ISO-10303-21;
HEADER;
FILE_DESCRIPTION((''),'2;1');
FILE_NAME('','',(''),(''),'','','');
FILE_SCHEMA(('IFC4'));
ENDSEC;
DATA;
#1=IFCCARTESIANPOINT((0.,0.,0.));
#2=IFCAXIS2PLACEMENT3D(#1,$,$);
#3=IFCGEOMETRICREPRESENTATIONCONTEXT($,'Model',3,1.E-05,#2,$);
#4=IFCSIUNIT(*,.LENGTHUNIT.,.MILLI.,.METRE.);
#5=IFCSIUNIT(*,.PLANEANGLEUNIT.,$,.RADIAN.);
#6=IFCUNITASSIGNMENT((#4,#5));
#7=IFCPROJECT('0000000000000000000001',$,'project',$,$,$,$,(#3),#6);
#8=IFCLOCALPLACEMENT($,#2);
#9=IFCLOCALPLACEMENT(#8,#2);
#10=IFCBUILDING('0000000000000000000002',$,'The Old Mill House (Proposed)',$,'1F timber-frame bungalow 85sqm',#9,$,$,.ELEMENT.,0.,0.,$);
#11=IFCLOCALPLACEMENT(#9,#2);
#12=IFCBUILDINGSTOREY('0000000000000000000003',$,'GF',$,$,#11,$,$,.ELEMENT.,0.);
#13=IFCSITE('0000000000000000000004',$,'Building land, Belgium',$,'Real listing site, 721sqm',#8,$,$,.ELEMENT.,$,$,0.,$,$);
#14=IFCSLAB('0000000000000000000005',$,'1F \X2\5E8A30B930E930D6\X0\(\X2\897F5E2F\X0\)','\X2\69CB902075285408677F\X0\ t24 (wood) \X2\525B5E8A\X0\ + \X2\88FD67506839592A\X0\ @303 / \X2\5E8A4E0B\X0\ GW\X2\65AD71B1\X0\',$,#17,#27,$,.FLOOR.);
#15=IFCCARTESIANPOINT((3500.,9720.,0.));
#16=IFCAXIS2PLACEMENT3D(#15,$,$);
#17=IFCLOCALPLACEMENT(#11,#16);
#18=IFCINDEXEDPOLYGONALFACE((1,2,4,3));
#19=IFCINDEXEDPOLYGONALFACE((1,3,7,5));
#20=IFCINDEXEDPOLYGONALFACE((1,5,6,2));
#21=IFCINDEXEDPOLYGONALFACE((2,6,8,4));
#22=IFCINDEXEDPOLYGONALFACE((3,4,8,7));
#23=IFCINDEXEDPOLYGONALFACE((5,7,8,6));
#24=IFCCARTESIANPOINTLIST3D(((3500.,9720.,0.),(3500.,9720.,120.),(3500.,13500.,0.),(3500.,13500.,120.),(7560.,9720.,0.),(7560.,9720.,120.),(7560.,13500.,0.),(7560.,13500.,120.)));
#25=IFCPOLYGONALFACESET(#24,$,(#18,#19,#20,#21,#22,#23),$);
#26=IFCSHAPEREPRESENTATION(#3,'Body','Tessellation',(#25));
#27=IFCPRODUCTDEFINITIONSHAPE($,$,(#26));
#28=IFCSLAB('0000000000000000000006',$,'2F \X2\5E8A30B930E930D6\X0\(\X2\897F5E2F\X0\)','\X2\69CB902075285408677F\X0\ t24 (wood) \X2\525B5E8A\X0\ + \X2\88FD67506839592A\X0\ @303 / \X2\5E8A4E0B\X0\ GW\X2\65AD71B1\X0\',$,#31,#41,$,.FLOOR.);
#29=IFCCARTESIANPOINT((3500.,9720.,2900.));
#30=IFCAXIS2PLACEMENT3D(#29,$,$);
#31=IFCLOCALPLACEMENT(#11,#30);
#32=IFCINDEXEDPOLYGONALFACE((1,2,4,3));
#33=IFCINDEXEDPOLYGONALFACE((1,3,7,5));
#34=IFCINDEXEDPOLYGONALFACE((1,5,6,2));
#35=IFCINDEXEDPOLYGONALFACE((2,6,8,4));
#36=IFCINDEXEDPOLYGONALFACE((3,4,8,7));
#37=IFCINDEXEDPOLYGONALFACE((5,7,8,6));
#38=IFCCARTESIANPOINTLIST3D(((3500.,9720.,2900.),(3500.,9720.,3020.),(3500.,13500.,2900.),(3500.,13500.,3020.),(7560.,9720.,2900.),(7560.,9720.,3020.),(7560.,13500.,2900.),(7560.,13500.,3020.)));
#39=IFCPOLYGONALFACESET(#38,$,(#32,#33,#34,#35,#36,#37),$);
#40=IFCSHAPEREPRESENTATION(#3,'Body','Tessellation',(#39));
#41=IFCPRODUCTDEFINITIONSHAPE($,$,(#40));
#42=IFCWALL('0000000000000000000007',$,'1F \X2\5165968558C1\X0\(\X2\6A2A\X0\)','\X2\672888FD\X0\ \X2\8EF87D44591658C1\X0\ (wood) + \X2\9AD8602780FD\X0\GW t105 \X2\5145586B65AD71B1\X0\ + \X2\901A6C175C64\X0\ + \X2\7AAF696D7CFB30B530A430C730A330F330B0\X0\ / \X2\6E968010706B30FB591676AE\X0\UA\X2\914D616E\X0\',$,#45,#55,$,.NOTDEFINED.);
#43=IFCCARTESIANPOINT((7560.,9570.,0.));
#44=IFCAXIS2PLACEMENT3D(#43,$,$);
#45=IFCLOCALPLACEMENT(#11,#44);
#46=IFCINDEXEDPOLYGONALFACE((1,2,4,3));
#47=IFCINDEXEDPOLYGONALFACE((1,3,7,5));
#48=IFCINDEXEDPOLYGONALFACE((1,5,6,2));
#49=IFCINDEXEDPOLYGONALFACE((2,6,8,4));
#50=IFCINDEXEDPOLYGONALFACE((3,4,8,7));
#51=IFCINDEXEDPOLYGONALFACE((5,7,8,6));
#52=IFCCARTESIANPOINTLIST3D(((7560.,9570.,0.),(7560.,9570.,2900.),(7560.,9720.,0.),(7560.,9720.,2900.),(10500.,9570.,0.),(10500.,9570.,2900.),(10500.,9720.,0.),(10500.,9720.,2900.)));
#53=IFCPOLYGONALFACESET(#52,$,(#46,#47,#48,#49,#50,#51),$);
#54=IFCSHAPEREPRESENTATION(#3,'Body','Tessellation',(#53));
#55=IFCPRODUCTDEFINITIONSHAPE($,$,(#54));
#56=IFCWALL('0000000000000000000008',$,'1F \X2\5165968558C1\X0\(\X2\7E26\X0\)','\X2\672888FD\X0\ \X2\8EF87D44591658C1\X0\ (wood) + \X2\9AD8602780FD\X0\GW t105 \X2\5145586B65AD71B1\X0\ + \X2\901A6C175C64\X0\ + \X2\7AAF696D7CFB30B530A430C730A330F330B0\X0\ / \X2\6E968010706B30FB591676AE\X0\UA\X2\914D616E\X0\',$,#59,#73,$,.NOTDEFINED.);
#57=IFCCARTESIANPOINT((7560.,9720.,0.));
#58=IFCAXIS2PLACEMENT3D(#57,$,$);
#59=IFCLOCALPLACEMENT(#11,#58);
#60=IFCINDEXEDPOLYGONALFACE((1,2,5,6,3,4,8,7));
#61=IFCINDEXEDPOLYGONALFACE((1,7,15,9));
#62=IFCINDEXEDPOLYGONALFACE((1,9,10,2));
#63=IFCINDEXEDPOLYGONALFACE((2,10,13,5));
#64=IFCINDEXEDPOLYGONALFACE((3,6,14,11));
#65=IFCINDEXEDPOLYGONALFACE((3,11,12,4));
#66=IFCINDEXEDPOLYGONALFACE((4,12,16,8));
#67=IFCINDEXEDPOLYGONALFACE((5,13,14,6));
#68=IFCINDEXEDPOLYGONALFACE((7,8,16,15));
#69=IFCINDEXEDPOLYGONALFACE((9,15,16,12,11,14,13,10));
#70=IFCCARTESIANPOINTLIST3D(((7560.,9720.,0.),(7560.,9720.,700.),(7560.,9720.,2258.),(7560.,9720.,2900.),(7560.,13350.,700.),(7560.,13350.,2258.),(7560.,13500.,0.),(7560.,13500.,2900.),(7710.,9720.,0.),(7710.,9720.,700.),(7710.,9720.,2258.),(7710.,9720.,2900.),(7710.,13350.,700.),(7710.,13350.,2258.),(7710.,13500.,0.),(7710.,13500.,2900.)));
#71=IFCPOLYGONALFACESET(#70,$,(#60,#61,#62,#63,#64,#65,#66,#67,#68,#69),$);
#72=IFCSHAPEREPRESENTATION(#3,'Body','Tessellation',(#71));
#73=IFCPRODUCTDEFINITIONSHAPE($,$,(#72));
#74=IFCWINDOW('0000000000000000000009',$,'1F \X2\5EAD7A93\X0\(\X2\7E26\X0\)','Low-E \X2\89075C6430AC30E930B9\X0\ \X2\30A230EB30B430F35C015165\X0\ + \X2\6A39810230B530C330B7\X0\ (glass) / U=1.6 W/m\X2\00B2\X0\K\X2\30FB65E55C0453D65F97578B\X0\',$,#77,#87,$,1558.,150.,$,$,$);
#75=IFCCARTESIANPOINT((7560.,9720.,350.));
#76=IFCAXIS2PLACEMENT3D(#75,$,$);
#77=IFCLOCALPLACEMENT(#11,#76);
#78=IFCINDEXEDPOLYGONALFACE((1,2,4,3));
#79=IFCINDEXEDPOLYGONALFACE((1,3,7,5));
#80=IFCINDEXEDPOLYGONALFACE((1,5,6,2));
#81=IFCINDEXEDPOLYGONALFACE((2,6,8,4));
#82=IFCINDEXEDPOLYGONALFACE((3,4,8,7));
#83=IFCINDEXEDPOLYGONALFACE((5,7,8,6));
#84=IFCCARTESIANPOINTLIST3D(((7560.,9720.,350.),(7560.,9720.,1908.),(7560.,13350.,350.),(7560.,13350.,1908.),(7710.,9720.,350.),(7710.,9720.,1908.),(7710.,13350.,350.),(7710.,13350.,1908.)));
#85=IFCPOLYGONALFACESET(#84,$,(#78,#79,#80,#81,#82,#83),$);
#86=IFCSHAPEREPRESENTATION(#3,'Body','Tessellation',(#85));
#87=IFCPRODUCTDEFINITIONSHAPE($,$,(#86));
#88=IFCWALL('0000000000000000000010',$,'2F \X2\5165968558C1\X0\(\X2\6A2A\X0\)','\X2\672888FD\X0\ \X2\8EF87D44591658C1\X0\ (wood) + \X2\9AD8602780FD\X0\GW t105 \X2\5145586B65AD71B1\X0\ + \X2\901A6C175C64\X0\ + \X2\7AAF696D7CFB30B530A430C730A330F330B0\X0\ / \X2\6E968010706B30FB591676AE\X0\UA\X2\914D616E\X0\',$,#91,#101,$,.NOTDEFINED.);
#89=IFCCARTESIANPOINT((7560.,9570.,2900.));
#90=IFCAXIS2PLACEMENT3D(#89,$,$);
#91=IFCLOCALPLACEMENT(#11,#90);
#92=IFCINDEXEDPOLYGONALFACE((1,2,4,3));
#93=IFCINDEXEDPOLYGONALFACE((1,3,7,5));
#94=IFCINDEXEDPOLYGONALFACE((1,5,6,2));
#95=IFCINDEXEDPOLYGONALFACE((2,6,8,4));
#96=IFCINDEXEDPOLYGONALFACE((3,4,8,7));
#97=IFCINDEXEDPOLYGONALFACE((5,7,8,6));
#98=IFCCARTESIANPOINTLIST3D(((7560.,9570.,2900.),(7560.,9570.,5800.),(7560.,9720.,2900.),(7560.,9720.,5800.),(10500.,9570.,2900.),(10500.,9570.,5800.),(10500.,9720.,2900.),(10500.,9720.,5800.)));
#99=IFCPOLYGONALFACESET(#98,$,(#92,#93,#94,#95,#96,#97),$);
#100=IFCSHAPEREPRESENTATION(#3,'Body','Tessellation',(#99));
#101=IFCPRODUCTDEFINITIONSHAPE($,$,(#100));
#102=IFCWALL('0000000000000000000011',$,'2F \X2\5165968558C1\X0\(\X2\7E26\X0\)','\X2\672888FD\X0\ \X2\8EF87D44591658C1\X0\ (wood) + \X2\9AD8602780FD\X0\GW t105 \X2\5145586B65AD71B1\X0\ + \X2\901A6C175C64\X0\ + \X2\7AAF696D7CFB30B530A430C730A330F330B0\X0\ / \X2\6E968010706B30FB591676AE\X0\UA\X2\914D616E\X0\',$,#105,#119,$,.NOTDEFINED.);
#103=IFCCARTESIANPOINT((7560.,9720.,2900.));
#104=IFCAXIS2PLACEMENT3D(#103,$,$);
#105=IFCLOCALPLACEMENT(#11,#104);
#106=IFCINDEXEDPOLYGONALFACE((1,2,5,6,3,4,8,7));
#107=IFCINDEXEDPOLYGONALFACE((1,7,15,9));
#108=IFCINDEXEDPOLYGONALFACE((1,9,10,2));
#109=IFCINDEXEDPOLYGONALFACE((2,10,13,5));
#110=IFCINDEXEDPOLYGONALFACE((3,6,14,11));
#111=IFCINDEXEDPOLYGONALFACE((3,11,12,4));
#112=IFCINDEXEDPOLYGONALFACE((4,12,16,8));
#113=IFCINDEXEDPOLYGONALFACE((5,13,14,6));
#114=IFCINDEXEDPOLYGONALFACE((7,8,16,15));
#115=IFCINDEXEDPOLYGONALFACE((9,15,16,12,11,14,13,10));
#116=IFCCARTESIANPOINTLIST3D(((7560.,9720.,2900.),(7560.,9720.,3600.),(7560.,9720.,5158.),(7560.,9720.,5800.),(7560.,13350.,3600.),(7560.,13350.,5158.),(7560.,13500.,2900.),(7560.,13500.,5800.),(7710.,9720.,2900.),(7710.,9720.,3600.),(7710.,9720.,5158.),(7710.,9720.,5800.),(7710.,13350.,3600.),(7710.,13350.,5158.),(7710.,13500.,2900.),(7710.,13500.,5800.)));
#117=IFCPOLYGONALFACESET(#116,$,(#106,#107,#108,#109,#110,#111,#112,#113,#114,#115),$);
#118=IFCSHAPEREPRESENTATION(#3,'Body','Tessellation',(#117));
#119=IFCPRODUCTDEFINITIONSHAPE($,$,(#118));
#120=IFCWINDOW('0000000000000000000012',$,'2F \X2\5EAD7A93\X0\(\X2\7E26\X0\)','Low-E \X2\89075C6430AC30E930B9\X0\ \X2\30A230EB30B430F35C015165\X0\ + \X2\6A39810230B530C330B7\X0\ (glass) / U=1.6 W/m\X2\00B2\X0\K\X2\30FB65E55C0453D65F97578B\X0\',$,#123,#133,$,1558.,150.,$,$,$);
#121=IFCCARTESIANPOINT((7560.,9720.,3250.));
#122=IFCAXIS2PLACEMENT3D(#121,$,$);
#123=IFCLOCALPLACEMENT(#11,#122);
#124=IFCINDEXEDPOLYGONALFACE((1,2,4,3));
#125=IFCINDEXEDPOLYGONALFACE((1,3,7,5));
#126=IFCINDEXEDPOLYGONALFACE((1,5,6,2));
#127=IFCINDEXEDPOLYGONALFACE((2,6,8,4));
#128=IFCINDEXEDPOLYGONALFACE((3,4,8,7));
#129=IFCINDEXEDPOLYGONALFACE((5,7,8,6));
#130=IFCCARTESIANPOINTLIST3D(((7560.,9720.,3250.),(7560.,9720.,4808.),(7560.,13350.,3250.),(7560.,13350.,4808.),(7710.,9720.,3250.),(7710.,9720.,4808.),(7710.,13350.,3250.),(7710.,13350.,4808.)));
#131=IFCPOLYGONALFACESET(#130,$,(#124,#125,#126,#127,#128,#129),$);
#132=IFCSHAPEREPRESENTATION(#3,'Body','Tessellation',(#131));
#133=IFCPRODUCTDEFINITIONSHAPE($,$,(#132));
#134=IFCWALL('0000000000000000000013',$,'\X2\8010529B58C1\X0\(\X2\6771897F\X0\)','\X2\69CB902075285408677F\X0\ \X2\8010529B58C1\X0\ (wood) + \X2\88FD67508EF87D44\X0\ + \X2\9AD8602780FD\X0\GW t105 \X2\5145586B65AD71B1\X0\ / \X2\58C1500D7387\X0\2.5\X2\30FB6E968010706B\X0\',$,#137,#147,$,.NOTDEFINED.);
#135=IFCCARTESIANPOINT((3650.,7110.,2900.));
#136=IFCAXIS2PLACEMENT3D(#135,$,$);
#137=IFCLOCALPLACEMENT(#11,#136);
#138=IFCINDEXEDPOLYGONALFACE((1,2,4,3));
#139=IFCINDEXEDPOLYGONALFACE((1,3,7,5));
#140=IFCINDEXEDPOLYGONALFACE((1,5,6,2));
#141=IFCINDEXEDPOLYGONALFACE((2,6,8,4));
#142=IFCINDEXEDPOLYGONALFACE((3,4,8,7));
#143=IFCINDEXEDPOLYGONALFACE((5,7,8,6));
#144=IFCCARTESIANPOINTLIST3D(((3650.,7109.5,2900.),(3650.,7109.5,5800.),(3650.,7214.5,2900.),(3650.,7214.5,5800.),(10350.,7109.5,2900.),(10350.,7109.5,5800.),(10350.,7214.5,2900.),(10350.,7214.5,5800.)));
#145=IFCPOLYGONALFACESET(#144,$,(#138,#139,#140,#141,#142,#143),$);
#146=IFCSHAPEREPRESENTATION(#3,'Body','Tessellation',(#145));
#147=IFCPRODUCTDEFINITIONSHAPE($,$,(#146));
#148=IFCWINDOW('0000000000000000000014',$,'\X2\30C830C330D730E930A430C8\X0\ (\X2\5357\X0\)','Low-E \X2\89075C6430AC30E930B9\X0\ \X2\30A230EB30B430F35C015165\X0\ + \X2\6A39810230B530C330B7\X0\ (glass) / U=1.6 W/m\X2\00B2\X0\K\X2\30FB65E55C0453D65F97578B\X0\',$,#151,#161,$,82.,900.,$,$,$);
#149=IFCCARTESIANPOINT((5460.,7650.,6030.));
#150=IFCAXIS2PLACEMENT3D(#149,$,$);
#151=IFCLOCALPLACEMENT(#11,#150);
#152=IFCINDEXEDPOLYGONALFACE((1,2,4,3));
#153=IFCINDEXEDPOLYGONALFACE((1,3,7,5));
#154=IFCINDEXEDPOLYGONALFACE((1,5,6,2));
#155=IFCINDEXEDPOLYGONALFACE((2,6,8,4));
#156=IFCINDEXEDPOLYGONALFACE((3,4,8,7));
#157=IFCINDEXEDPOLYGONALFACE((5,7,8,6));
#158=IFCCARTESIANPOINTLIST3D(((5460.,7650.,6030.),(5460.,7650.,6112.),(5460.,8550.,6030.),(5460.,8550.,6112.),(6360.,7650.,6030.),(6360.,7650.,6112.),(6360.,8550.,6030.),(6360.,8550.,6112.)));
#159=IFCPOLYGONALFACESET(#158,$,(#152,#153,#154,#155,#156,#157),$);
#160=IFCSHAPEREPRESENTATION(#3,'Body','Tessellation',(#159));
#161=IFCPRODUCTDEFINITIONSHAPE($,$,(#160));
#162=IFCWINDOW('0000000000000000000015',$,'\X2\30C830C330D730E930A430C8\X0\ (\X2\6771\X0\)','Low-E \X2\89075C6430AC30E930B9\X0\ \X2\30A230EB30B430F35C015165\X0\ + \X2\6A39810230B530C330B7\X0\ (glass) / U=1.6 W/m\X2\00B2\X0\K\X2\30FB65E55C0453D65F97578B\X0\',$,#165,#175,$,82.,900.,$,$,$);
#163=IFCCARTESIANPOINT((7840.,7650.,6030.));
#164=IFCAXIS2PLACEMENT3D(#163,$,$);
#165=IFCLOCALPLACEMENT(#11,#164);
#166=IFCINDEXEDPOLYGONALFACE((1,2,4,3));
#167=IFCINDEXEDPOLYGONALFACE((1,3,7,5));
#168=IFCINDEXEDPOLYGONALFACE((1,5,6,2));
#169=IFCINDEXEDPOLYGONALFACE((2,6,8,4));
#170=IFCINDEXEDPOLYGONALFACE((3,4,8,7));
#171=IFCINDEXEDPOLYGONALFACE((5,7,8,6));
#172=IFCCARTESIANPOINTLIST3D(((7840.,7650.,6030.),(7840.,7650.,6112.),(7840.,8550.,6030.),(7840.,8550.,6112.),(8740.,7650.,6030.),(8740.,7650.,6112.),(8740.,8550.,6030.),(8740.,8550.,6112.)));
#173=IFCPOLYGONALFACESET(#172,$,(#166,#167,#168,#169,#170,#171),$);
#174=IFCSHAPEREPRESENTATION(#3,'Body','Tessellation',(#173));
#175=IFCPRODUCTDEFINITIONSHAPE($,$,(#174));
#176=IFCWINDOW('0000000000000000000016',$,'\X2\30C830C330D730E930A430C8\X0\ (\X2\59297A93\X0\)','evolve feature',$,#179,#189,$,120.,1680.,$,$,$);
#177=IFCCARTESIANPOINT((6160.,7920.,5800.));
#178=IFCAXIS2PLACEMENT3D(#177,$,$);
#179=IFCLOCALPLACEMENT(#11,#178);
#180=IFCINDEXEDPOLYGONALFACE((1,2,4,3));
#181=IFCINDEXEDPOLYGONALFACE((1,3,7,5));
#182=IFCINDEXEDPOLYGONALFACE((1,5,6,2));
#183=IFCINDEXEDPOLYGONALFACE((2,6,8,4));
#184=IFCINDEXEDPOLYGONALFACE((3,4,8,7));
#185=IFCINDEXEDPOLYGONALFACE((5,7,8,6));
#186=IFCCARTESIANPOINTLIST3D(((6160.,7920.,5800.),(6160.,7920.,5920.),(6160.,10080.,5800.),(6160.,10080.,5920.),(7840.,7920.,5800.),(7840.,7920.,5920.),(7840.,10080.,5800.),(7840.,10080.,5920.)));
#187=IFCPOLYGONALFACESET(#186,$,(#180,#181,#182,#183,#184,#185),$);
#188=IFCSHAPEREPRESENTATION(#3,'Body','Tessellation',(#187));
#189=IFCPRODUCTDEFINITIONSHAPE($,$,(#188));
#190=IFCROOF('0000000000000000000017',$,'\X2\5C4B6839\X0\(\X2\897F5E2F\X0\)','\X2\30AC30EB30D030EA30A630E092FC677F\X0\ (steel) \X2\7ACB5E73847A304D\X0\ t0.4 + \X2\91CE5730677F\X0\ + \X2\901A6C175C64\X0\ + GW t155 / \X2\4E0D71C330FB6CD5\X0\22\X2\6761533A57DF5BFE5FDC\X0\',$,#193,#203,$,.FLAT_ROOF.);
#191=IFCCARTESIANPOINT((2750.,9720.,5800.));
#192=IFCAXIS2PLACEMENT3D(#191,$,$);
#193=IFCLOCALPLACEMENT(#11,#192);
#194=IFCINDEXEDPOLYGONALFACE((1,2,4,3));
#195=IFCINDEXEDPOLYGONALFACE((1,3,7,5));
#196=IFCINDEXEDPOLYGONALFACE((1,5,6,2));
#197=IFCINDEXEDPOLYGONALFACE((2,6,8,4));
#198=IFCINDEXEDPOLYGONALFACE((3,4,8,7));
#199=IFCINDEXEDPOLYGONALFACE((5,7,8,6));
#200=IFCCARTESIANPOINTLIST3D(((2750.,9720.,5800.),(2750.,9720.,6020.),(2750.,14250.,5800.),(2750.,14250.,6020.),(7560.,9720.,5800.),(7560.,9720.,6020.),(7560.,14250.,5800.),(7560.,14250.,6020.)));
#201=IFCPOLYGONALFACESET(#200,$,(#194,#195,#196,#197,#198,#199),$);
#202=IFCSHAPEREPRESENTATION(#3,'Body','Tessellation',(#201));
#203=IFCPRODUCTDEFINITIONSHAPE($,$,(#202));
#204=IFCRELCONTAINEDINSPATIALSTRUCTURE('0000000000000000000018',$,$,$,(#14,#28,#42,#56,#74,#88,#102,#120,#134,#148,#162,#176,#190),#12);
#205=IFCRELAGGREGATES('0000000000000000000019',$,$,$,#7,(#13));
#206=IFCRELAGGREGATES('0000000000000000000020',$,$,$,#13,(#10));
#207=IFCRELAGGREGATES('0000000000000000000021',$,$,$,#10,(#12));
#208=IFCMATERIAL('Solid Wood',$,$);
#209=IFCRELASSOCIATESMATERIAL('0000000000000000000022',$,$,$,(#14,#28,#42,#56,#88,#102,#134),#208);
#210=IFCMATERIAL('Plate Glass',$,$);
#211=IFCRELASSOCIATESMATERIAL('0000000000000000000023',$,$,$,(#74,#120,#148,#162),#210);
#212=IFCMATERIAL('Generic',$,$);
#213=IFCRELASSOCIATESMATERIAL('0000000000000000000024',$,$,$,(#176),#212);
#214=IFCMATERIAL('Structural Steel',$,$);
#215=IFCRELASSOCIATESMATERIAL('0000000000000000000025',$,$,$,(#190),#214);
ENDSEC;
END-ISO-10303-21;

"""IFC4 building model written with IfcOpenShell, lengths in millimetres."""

from ifc_helpers import new_model, si_unit, frame, frame_2d, origin, place, context, project, spatial, rectangle, extrude, material, element, fill, save


model = new_model("IFC4")

# Units and contexts
model_context = context("Model", 3, precision=1e-05, world=origin())
ifc_project = project(units=[si_unit("LENGTHUNIT", "METRE", prefix="MILLI"), si_unit("PLANEANGLEUNIT", "RADIAN")], contexts=[model_context])

# Site, building, storey
site_placement = place(None, origin())
site = spatial("IfcSite", under=ifc_project, at=site_placement, Name="Building land, Belgium", ObjectType="Real listing site, 721sqm", CompositionType="ELEMENT", RefElevation=0.0)
building_placement = place(site_placement, origin())
building = spatial("IfcBuilding", under=site, at=building_placement, Name="The Old Mill House (Proposed)", ObjectType="1F timber-frame bungalow 85sqm", CompositionType="ELEMENT", ElevationOfRefHeight=0.0, ElevationOfTerrain=0.0)
storey_placement = place(building_placement, origin())
storey = spatial("IfcBuildingStorey", under=building, at=storey_placement, Name="GF", CompositionType="ELEMENT", Elevation=0.0)

# Slabs
ifc_material_1 = material(Name="Solid Wood")
slab_1_placement = place(storey_placement, frame((3500.0, 9720.0, 0.0)))
element("IfcSlab", 1, at=slab_1_placement, inside=storey, material=ifc_material_1, Name="1F 床スラブ(西帯)", Description="構造用合板 t24 (wood) 剛床 + 製材根太 @303 / 床下 GW断熱", PredefinedType="FLOOR", context=model_context, shape_type="SweptSolid", body=[
    extrude(rectangle(XDim=4060.0, YDim=3780.0, at=frame_2d((2030.0, 1890.0))), frame((3500.0, 9720.0, 0.0)), (0.0, 0.0, 1.0), 120.0),
])
slab_2_placement = place(storey_placement, frame((3500.0, 9720.0, 2900.0)))
element("IfcSlab", 2, at=slab_2_placement, inside=storey, material=ifc_material_1, Name="2F 床スラブ(西帯)", Description="構造用合板 t24 (wood) 剛床 + 製材根太 @303 / 床下 GW断熱", PredefinedType="FLOOR", context=model_context, shape_type="SweptSolid", body=[
    extrude(rectangle(XDim=4060.0, YDim=3780.0, at=frame_2d((2030.0, 1890.0))), frame((3500.0, 9720.0, 2900.0)), (0.0, 0.0, 1.0), 120.0),
])

# Wall
wall_1_placement = place(storey_placement, frame((7560.0, 9570.0, 0.0)))
element("IfcWall", 3, at=wall_1_placement, inside=storey, material=ifc_material_1, Name="1F 入隅壁(横)", Description="木製 軸組外壁 (wood) + 高性能GW t105 充填断熱 + 通気層 + 窯業系サイディング / 準耐火・外皮UA配慮", PredefinedType="NOTDEFINED", context=model_context, shape_type="SweptSolid", body=[
    extrude(rectangle(XDim=2940.0, YDim=150.0, at=frame_2d((1470.0, 75.0))), frame((7560.0, 9570.0, 0.0)), (0.0, 0.0, 1.0), 2900.0),
])

# Wall, opening, window
wall_2_placement = place(storey_placement, frame((7560.0, 9720.0, 0.0)))
wall_2 = element("IfcWall", 4, at=wall_2_placement, inside=storey, material=ifc_material_1, Name="1F 入隅壁(縦)", Description="木製 軸組外壁 (wood) + 高性能GW t105 充填断熱 + 通気層 + 窯業系サイディング / 準耐火・外皮UA配慮", PredefinedType="NOTDEFINED", context=model_context, shape_type="SweptSolid", body=[
    extrude(rectangle(XDim=150.0, YDim=3780.0, at=frame_2d((75.0, 1890.0))), frame((7560.0, 9720.0, 0.0)), (0.0, 0.0, 1.0), 2900.0),
])
opening_1_placement = place(storey_placement, frame((7560.0, 9720.0, 350.0)))
opening_1 = element("IfcOpeningElement", 5, at=opening_1_placement, cuts=wall_2, PredefinedType="NOTDEFINED", context=model_context, shape_type="SweptSolid", body=[
    extrude(rectangle(XDim=150.0, YDim=3630.0, at=frame_2d((75.0, 1815.0))), frame((7560.0, 9720.0, 350.0)), (0.0, 0.0, 1.0), 1558.0),
])
ifc_material_2 = material(Name="Plate Glass")
window_1_placement = place(storey_placement, frame((7560.0, 9720.0, 350.0)))
window_1 = element("IfcWindow", 6, at=window_1_placement, inside=storey, material=ifc_material_2, Name="1F 庭窓(縦)", Description="Low-E 複層ガラス アルゴン封入 + 樹脂サッシ (glass) / U=1.6 W/m²K・日射取得型", OverallHeight=1558.0, OverallWidth=150.0, context=model_context, shape_type="SweptSolid", body=[
    extrude(rectangle(XDim=150.0, YDim=3630.0, at=frame_2d((75.0, 1815.0))), frame((7560.0, 9720.0, 350.0)), (0.0, 0.0, 1.0), 1558.0),
])
fill(opening_1, window_1)

# Wall
wall_3_placement = place(storey_placement, frame((7560.0, 9570.0, 2900.0)))
element("IfcWall", 7, at=wall_3_placement, inside=storey, material=ifc_material_1, Name="2F 入隅壁(横)", Description="木製 軸組外壁 (wood) + 高性能GW t105 充填断熱 + 通気層 + 窯業系サイディング / 準耐火・外皮UA配慮", PredefinedType="NOTDEFINED", context=model_context, shape_type="SweptSolid", body=[
    extrude(rectangle(XDim=2940.0, YDim=150.0, at=frame_2d((1470.0, 75.0))), frame((7560.0, 9570.0, 2900.0)), (0.0, 0.0, 1.0), 2900.0),
])

# Wall, opening, window
wall_4_placement = place(storey_placement, frame((7560.0, 9720.0, 2900.0)))
wall_4 = element("IfcWall", 8, at=wall_4_placement, inside=storey, material=ifc_material_1, Name="2F 入隅壁(縦)", Description="木製 軸組外壁 (wood) + 高性能GW t105 充填断熱 + 通気層 + 窯業系サイディング / 準耐火・外皮UA配慮", PredefinedType="NOTDEFINED", context=model_context, shape_type="SweptSolid", body=[
    extrude(rectangle(XDim=150.0, YDim=3780.0, at=frame_2d((75.0, 1890.0))), frame((7560.0, 9720.0, 2900.0)), (0.0, 0.0, 1.0), 2900.0),
])
opening_2_placement = place(storey_placement, frame((7560.0, 9720.0, 3250.0)))
opening_2 = element("IfcOpeningElement", 9, at=opening_2_placement, cuts=wall_4, PredefinedType="NOTDEFINED", context=model_context, shape_type="SweptSolid", body=[
    extrude(rectangle(XDim=150.0, YDim=3630.0, at=frame_2d((75.0, 1815.0))), frame((7560.0, 9720.0, 3250.0)), (0.0, 0.0, 1.0), 1558.0),
])
window_2_placement = place(storey_placement, frame((7560.0, 9720.0, 3250.0)))
window_2 = element("IfcWindow", 10, at=window_2_placement, inside=storey, material=ifc_material_2, Name="2F 庭窓(縦)", Description="Low-E 複層ガラス アルゴン封入 + 樹脂サッシ (glass) / U=1.6 W/m²K・日射取得型", OverallHeight=1558.0, OverallWidth=150.0, context=model_context, shape_type="SweptSolid", body=[
    extrude(rectangle(XDim=150.0, YDim=3630.0, at=frame_2d((75.0, 1815.0))), frame((7560.0, 9720.0, 3250.0)), (0.0, 0.0, 1.0), 1558.0),
])
fill(opening_2, window_2)

# Wall
wall_5_placement = place(storey_placement, frame((3650.0, 7110.0, 2900.0)))
element("IfcWall", 11, at=wall_5_placement, inside=storey, material=ifc_material_1, Name="耐力壁(東西)", Description="構造用合板 耐力壁 (wood) + 製材軸組 + 高性能GW t105 充填断熱 / 壁倍率2.5・準耐火", PredefinedType="NOTDEFINED", context=model_context, shape_type="SweptSolid", body=[
    extrude(rectangle(XDim=6700.0, YDim=105.0, at=frame_2d((3350.0, 52.0))), frame((3650.0, 7110.0, 2900.0)), (0.0, 0.0, 1.0), 2900.0),
])

# Windows
window_3_placement = place(storey_placement, frame((5460.0, 7650.0, 6030.0)))
element("IfcWindow", 12, at=window_3_placement, inside=storey, material=ifc_material_2, Name="トップライト (南)", Description="Low-E 複層ガラス アルゴン封入 + 樹脂サッシ (glass) / U=1.6 W/m²K・日射取得型", OverallHeight=82.0, OverallWidth=900.0, context=model_context, shape_type="SweptSolid", body=[
    extrude(rectangle(XDim=900.0, YDim=900.0, at=frame_2d((450.0, 450.0))), frame((5460.0, 7650.0, 6030.0)), (0.0, 0.0, 1.0), 82.0),
])
window_4_placement = place(storey_placement, frame((7840.0, 7650.0, 6030.0)))
element("IfcWindow", 13, at=window_4_placement, inside=storey, material=ifc_material_2, Name="トップライト (東)", Description="Low-E 複層ガラス アルゴン封入 + 樹脂サッシ (glass) / U=1.6 W/m²K・日射取得型", OverallHeight=82.0, OverallWidth=900.0, context=model_context, shape_type="SweptSolid", body=[
    extrude(rectangle(XDim=900.0, YDim=900.0, at=frame_2d((450.0, 450.0))), frame((7840.0, 7650.0, 6030.0)), (0.0, 0.0, 1.0), 82.0),
])
ifc_material_3 = material(Name="Generic")
window_5_placement = place(storey_placement, frame((6160.0, 7920.0, 5800.0)))
element("IfcWindow", 14, at=window_5_placement, inside=storey, material=ifc_material_3, Name="トップライト (天窓)", Description="evolve feature", OverallHeight=120.0, OverallWidth=1680.0, context=model_context, shape_type="SweptSolid", body=[
    extrude(rectangle(XDim=1680.0, YDim=2160.0, at=frame_2d((840.0, 1080.0))), frame((6160.0, 7920.0, 5800.0)), (0.0, 0.0, 1.0), 120.0),
])

# Roof
ifc_material_4 = material(Name="Structural Steel")
for number, where, name in (
    (15, (2750.0, 9720.0, 5800.0), "屋根(西帯)"),
):
    element("IfcRoof", number, at=place(storey_placement, frame(where)), inside=storey, material=ifc_material_4, Name=name, Description="ガルバリウム鋼板 (steel) 立平葺き t0.4 + 野地板 + 通気層 + GW t155 / 不燃・法22条区域対応", PredefinedType="FLAT_ROOF", context=model_context, shape_type="SweptSolid", body=[
        extrude(rectangle(XDim=4810.0, YDim=4530.0, at=frame_2d((2405.0, 2265.0))), frame((2750.0, 9720.0, 5800.0)), (0.0, 0.0, 1.0), 220.0),
    ])

save(model, "model.ifc")
